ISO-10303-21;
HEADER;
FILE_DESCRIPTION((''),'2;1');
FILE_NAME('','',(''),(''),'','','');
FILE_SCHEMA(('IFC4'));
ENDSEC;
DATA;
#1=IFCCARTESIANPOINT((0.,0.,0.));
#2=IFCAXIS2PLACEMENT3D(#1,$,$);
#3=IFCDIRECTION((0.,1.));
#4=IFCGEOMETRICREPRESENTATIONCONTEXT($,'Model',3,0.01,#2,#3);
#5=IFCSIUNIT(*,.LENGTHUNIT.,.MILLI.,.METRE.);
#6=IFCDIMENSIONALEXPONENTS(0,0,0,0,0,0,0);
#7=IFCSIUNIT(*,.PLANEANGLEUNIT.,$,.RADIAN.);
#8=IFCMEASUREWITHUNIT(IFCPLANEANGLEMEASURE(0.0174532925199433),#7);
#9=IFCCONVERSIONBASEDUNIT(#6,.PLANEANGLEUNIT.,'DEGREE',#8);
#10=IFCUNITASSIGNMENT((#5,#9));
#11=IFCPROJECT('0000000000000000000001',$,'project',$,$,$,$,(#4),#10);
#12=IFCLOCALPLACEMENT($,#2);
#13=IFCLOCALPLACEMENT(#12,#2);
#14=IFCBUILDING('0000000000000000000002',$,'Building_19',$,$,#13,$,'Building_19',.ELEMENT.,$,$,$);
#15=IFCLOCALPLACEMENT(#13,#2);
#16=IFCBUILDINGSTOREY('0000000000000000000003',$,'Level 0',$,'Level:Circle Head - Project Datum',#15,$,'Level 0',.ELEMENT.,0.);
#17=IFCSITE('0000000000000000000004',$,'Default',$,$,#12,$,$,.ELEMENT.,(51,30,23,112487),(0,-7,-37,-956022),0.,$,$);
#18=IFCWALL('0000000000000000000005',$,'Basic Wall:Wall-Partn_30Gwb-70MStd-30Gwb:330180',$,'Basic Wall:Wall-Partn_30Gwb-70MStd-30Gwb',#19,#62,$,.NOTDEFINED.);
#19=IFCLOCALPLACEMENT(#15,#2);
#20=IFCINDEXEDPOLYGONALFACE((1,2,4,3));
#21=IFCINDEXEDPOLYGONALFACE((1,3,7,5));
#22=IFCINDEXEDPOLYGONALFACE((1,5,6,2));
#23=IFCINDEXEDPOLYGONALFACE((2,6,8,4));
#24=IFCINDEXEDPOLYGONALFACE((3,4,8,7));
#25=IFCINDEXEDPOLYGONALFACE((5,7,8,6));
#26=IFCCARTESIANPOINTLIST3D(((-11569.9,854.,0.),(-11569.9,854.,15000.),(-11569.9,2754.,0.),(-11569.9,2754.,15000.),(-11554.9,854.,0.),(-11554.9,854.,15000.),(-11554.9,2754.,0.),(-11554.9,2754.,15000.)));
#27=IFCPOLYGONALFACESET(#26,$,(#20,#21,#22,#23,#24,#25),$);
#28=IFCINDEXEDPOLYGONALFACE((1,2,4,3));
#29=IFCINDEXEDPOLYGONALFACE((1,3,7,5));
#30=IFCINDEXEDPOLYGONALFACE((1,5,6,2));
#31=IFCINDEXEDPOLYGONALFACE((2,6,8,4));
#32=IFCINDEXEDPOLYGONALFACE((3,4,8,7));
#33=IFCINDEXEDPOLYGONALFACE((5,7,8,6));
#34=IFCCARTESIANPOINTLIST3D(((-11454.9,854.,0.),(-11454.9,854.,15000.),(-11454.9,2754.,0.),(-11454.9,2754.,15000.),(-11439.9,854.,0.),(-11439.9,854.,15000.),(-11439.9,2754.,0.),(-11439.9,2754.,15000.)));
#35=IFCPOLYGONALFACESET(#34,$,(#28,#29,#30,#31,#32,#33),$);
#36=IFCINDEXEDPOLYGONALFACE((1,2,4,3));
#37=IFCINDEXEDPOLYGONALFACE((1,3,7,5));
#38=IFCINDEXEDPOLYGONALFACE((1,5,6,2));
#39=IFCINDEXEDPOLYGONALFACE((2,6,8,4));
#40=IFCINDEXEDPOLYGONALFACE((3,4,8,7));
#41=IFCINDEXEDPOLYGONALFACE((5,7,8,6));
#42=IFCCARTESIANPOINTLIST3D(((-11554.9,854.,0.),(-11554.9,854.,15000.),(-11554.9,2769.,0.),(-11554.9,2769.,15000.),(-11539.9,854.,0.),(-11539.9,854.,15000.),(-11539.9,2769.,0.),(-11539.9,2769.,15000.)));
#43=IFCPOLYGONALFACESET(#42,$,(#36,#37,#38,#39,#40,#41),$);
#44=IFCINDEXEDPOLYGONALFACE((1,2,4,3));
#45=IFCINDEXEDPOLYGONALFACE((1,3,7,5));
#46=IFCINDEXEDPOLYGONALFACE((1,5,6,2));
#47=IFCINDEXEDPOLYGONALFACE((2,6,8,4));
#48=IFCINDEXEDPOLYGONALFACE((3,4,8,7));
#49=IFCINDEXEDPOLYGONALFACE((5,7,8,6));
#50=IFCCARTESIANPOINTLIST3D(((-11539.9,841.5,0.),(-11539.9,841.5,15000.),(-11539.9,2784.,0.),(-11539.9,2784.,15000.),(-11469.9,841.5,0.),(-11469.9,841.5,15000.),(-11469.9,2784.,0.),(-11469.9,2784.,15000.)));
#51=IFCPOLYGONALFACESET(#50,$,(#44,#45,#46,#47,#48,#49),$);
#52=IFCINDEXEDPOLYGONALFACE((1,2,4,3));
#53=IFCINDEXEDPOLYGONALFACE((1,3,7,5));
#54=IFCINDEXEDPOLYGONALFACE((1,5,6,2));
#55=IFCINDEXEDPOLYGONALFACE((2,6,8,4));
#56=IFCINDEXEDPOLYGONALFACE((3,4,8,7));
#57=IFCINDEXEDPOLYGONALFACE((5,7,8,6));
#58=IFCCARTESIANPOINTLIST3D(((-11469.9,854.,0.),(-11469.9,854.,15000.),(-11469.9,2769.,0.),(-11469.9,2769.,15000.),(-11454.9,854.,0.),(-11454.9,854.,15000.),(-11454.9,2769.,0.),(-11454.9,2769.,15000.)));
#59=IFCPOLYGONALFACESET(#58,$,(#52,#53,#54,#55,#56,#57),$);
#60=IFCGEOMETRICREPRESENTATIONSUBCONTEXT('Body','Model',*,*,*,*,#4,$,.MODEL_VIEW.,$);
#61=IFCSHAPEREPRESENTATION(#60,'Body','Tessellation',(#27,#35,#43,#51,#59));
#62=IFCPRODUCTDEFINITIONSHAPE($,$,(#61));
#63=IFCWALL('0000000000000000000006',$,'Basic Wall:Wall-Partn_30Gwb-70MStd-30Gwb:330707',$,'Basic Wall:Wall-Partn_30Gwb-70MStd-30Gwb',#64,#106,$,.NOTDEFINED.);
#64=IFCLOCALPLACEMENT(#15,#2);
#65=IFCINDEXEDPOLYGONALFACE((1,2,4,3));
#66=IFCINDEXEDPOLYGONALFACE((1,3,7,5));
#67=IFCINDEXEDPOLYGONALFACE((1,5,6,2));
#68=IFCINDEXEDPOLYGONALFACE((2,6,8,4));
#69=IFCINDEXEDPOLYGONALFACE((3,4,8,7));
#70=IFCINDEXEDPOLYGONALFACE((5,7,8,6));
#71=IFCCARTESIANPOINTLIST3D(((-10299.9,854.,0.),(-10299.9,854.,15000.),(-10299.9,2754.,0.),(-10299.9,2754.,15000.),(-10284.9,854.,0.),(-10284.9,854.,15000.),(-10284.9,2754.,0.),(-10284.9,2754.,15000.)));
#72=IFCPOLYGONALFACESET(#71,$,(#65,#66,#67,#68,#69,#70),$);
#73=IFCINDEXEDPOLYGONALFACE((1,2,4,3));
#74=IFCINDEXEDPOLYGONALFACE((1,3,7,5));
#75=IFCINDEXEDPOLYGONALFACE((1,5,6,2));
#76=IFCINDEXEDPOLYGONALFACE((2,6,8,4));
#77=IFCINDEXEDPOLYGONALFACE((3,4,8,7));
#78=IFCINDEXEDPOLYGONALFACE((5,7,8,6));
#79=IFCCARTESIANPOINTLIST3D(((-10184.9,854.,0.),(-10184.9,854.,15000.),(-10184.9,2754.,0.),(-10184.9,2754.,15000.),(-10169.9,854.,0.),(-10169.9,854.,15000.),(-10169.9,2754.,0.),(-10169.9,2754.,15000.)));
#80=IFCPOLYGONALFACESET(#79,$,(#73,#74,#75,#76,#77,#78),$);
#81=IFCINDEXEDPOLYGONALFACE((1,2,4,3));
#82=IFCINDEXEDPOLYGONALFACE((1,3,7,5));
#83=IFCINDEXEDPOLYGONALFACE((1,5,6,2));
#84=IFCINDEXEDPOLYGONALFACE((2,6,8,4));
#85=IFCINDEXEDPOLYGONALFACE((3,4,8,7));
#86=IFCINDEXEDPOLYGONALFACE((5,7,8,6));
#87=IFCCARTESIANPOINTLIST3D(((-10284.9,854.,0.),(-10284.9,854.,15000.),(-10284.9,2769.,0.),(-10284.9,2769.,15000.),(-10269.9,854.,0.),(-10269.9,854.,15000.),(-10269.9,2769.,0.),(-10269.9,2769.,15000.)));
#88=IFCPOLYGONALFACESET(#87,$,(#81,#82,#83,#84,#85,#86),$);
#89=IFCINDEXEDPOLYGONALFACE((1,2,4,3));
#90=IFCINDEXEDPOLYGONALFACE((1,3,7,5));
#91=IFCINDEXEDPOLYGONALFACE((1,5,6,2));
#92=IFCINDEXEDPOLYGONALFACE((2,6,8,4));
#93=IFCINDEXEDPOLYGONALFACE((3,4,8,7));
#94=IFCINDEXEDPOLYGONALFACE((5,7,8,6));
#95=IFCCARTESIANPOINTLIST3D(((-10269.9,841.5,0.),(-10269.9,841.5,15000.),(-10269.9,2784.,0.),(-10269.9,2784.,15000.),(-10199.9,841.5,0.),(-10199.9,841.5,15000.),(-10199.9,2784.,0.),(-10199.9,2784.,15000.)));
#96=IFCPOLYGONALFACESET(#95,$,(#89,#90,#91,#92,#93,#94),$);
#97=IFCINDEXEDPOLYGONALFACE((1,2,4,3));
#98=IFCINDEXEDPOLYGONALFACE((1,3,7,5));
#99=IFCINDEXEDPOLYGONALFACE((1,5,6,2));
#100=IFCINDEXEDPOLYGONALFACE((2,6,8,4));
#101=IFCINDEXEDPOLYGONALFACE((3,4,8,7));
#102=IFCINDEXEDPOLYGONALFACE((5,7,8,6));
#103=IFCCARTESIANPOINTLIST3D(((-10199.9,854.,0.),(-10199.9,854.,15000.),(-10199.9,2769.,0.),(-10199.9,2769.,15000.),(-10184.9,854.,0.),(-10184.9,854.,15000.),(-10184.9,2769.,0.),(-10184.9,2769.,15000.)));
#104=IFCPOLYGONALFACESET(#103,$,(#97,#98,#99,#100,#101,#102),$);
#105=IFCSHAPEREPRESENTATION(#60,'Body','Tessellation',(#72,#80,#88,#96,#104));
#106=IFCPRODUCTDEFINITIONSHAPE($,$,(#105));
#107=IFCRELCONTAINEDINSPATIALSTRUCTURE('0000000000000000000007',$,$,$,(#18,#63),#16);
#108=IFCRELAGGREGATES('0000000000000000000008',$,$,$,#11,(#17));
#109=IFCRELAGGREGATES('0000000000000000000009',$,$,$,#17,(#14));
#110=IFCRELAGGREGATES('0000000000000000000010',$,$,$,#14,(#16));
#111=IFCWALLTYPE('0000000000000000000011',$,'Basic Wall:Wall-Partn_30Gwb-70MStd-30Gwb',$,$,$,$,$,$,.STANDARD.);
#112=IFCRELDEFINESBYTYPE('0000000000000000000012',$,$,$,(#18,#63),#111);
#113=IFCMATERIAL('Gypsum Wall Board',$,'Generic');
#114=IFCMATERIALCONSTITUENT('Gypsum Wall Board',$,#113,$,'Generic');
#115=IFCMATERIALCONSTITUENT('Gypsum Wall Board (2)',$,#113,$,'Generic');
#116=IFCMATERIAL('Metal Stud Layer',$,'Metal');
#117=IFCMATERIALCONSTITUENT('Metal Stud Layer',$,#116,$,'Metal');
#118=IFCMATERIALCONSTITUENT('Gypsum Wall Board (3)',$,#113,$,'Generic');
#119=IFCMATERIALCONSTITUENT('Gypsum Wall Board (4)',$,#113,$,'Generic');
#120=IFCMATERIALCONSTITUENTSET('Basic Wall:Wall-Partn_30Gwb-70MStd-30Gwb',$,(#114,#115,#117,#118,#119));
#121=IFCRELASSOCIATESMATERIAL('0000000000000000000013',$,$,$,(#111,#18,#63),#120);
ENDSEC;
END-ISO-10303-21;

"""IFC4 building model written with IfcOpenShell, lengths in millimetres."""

from ifc_helpers import new_model, entity, si_unit, converted_unit, direction, frame, origin, place, context, subcontext, project, spatial, indexed_curve, outline, extrude, material, constituent, constituent_set, type_object, element, save


model = new_model("IFC4")

# Units and contexts
model_context = context("Model", 3, precision=0.01, world=origin(), true_north=direction((0.0, 1.0)))
body_context = subcontext(model_context, "Body", "Model", "MODEL_VIEW")
ifc_project = project(units=[si_unit("LENGTHUNIT", "METRE", prefix="MILLI"), converted_unit("PLANEANGLEUNIT", "DEGREE", entity("IfcPlaneAngleMeasure", 0.0174532925199433), si_unit("PLANEANGLEUNIT", "RADIAN"), dimensions=[0, 0, 0, 0, 0, 0, 0])], contexts=[model_context])

# Site, building, storey
site_placement = place(None, origin())
site = spatial("IfcSite", under=ifc_project, at=site_placement, Name="Default", CompositionType="ELEMENT", RefLatitude=(51, 30, 23, 112487), RefLongitude=(0, -7, -37, -956022), RefElevation=0.0)
building_placement = place(site_placement, origin())
building = spatial("IfcBuilding", under=site, at=building_placement, Name="Building_19", LongName="Building_19", CompositionType="ELEMENT")
storey_placement = place(building_placement, origin())
storey = spatial("IfcBuildingStorey", under=building, at=storey_placement, Name="Level 0", ObjectType="Level:Circle Head - Project Datum", LongName="Level 0", CompositionType="ELEMENT", Elevation=0.0)

# Shared definitions
ifc_material_1 = material(Name="Gypsum Wall Board", Category="Generic")
ifc_constituent_1 = constituent(ifc_material_1, Name="Gypsum Wall Board", Category="Generic")
ifc_constituent_2 = constituent(ifc_material_1, Name="Gypsum Wall Board (2)", Category="Generic")
ifc_material_2 = material(Name="Metal Stud Layer", Category="Metal")
ifc_constituent_3 = constituent(ifc_material_2, Name="Metal Stud Layer", Category="Metal")
ifc_constituent_4 = constituent(ifc_material_1, Name="Gypsum Wall Board (3)", Category="Generic")
ifc_constituent_5 = constituent(ifc_material_1, Name="Gypsum Wall Board (4)", Category="Generic")
ifc_constituent_set_1 = constituent_set(constituents=[ifc_constituent_1, ifc_constituent_2, ifc_constituent_3, ifc_constituent_4, ifc_constituent_5], Name="Basic Wall:Wall-Partn_30Gwb-70MStd-30Gwb")
wall_type_1 = type_object("IfcWallType", Name="Basic Wall:Wall-Partn_30Gwb-70MStd-30Gwb", PredefinedType="STANDARD", material=ifc_constituent_set_1)

# Walls
wall_1_placement = place(storey_placement, frame((-11504.9, 2754.0, 0.0), z_axis=(0.0, 0.0, 1.0), x_axis=(0.0, -1.0, 0.0)))
element("IfcWall", 1, at=wall_1_placement, inside=storey, type_object=wall_type_1, material=ifc_constituent_set_1, Name="Basic Wall:Wall-Partn_30Gwb-70MStd-30Gwb:330180", ObjectType="Basic Wall:Wall-Partn_30Gwb-70MStd-30Gwb", PredefinedType="NOTDEFINED", context=body_context, shape_type="SweptSolid", body=[
    extrude(outline(indexed_curve([(-7.5, -950.0), (7.5, -950.0), (7.5, 950.0), (-7.5, 950.0), (-7.5, -950.0)], self_intersect=False)), frame((950.0, -57.5, 0.0), z_axis=(0.0, 0.0, 1.0), x_axis=(0.0, 1.0, 0.0)), (0.0, 0.0, 1.0), 15000.0),
    extrude(outline(indexed_curve([(-7.5, -950.0), (7.5, -950.0), (7.5, 950.0), (-7.5, 950.0), (-7.5, -950.0)], self_intersect=False)), frame((950.0, 57.5, 0.0), z_axis=(0.0, 0.0, 1.0), x_axis=(0.0, -1.0, 0.0)), (0.0, 0.0, 1.0), 15000.0),
    extrude(outline(indexed_curve([(-957.5, -7.5), (957.5, -7.5), (957.5, 7.5), (-957.5, 7.5), (-957.5, -7.5)], self_intersect=False)), frame((942.5, -42.5, 0.0)), (0.0, 0.0, 1.0), 15000.0),
    extrude(outline(indexed_curve([(-971.2, -35.0), (971.2, -35.0), (971.2, 35.0), (-971.2, 35.0), (-971.2, -35.0)], self_intersect=False)), frame((941.2, 0.0, 0.0)), (0.0, 0.0, 1.0), 15000.0),
    extrude(outline(indexed_curve([(-957.5, -7.5), (957.5, -7.5), (957.5, 7.5), (-957.5, 7.5), (-957.5, -7.5)], self_intersect=False)), frame((942.5, 42.5, 0.0)), (0.0, 0.0, 1.0), 15000.0),
])
wall_2_placement = place(storey_placement, frame((-10234.9, 2754.0, 0.0), z_axis=(0.0, 0.0, 1.0), x_axis=(0.0, -1.0, 0.0)))
element("IfcWall", 2, at=wall_2_placement, inside=storey, type_object=wall_type_1, material=ifc_constituent_set_1, Name="Basic Wall:Wall-Partn_30Gwb-70MStd-30Gwb:330707", ObjectType="Basic Wall:Wall-Partn_30Gwb-70MStd-30Gwb", PredefinedType="NOTDEFINED", context=body_context, shape_type="SweptSolid", body=[
    extrude(outline(indexed_curve([(-7.5, -950.0), (7.5, -950.0), (7.5, 950.0), (-7.5, 950.0), (-7.5, -950.0)], self_intersect=False)), frame((950.0, -57.5, 0.0), z_axis=(0.0, 0.0, 1.0), x_axis=(0.0, 1.0, 0.0)), (0.0, 0.0, 1.0), 15000.0),
    extrude(outline(indexed_curve([(-7.5, -950.0), (7.5, -950.0), (7.5, 950.0), (-7.5, 950.0), (-7.5, -950.0)], self_intersect=False)), frame((950.0, 57.5, 0.0), z_axis=(0.0, 0.0, 1.0), x_axis=(0.0, -1.0, 0.0)), (0.0, 0.0, 1.0), 15000.0),
    extrude(outline(indexed_curve([(-957.5, -7.5), (957.5, -7.5), (957.5, 7.5), (-957.5, 7.5), (-957.5, -7.5)], self_intersect=False)), frame((942.5, -42.5, 0.0)), (0.0, 0.0, 1.0), 15000.0),
    extrude(outline(indexed_curve([(-971.2, -35.0), (971.2, -35.0), (971.2, 35.0), (-971.2, 35.0), (-971.2, -35.0)], self_intersect=False)), frame((941.2, 0.0, 0.0)), (0.0, 0.0, 1.0), 15000.0),
    extrude(outline(indexed_curve([(-957.5, -7.5), (957.5, -7.5), (957.5, 7.5), (-957.5, 7.5), (-957.5, -7.5)], self_intersect=False)), frame((942.5, 42.5, 0.0)), (0.0, 0.0, 1.0), 15000.0),
])

save(model, "model.ifc")
